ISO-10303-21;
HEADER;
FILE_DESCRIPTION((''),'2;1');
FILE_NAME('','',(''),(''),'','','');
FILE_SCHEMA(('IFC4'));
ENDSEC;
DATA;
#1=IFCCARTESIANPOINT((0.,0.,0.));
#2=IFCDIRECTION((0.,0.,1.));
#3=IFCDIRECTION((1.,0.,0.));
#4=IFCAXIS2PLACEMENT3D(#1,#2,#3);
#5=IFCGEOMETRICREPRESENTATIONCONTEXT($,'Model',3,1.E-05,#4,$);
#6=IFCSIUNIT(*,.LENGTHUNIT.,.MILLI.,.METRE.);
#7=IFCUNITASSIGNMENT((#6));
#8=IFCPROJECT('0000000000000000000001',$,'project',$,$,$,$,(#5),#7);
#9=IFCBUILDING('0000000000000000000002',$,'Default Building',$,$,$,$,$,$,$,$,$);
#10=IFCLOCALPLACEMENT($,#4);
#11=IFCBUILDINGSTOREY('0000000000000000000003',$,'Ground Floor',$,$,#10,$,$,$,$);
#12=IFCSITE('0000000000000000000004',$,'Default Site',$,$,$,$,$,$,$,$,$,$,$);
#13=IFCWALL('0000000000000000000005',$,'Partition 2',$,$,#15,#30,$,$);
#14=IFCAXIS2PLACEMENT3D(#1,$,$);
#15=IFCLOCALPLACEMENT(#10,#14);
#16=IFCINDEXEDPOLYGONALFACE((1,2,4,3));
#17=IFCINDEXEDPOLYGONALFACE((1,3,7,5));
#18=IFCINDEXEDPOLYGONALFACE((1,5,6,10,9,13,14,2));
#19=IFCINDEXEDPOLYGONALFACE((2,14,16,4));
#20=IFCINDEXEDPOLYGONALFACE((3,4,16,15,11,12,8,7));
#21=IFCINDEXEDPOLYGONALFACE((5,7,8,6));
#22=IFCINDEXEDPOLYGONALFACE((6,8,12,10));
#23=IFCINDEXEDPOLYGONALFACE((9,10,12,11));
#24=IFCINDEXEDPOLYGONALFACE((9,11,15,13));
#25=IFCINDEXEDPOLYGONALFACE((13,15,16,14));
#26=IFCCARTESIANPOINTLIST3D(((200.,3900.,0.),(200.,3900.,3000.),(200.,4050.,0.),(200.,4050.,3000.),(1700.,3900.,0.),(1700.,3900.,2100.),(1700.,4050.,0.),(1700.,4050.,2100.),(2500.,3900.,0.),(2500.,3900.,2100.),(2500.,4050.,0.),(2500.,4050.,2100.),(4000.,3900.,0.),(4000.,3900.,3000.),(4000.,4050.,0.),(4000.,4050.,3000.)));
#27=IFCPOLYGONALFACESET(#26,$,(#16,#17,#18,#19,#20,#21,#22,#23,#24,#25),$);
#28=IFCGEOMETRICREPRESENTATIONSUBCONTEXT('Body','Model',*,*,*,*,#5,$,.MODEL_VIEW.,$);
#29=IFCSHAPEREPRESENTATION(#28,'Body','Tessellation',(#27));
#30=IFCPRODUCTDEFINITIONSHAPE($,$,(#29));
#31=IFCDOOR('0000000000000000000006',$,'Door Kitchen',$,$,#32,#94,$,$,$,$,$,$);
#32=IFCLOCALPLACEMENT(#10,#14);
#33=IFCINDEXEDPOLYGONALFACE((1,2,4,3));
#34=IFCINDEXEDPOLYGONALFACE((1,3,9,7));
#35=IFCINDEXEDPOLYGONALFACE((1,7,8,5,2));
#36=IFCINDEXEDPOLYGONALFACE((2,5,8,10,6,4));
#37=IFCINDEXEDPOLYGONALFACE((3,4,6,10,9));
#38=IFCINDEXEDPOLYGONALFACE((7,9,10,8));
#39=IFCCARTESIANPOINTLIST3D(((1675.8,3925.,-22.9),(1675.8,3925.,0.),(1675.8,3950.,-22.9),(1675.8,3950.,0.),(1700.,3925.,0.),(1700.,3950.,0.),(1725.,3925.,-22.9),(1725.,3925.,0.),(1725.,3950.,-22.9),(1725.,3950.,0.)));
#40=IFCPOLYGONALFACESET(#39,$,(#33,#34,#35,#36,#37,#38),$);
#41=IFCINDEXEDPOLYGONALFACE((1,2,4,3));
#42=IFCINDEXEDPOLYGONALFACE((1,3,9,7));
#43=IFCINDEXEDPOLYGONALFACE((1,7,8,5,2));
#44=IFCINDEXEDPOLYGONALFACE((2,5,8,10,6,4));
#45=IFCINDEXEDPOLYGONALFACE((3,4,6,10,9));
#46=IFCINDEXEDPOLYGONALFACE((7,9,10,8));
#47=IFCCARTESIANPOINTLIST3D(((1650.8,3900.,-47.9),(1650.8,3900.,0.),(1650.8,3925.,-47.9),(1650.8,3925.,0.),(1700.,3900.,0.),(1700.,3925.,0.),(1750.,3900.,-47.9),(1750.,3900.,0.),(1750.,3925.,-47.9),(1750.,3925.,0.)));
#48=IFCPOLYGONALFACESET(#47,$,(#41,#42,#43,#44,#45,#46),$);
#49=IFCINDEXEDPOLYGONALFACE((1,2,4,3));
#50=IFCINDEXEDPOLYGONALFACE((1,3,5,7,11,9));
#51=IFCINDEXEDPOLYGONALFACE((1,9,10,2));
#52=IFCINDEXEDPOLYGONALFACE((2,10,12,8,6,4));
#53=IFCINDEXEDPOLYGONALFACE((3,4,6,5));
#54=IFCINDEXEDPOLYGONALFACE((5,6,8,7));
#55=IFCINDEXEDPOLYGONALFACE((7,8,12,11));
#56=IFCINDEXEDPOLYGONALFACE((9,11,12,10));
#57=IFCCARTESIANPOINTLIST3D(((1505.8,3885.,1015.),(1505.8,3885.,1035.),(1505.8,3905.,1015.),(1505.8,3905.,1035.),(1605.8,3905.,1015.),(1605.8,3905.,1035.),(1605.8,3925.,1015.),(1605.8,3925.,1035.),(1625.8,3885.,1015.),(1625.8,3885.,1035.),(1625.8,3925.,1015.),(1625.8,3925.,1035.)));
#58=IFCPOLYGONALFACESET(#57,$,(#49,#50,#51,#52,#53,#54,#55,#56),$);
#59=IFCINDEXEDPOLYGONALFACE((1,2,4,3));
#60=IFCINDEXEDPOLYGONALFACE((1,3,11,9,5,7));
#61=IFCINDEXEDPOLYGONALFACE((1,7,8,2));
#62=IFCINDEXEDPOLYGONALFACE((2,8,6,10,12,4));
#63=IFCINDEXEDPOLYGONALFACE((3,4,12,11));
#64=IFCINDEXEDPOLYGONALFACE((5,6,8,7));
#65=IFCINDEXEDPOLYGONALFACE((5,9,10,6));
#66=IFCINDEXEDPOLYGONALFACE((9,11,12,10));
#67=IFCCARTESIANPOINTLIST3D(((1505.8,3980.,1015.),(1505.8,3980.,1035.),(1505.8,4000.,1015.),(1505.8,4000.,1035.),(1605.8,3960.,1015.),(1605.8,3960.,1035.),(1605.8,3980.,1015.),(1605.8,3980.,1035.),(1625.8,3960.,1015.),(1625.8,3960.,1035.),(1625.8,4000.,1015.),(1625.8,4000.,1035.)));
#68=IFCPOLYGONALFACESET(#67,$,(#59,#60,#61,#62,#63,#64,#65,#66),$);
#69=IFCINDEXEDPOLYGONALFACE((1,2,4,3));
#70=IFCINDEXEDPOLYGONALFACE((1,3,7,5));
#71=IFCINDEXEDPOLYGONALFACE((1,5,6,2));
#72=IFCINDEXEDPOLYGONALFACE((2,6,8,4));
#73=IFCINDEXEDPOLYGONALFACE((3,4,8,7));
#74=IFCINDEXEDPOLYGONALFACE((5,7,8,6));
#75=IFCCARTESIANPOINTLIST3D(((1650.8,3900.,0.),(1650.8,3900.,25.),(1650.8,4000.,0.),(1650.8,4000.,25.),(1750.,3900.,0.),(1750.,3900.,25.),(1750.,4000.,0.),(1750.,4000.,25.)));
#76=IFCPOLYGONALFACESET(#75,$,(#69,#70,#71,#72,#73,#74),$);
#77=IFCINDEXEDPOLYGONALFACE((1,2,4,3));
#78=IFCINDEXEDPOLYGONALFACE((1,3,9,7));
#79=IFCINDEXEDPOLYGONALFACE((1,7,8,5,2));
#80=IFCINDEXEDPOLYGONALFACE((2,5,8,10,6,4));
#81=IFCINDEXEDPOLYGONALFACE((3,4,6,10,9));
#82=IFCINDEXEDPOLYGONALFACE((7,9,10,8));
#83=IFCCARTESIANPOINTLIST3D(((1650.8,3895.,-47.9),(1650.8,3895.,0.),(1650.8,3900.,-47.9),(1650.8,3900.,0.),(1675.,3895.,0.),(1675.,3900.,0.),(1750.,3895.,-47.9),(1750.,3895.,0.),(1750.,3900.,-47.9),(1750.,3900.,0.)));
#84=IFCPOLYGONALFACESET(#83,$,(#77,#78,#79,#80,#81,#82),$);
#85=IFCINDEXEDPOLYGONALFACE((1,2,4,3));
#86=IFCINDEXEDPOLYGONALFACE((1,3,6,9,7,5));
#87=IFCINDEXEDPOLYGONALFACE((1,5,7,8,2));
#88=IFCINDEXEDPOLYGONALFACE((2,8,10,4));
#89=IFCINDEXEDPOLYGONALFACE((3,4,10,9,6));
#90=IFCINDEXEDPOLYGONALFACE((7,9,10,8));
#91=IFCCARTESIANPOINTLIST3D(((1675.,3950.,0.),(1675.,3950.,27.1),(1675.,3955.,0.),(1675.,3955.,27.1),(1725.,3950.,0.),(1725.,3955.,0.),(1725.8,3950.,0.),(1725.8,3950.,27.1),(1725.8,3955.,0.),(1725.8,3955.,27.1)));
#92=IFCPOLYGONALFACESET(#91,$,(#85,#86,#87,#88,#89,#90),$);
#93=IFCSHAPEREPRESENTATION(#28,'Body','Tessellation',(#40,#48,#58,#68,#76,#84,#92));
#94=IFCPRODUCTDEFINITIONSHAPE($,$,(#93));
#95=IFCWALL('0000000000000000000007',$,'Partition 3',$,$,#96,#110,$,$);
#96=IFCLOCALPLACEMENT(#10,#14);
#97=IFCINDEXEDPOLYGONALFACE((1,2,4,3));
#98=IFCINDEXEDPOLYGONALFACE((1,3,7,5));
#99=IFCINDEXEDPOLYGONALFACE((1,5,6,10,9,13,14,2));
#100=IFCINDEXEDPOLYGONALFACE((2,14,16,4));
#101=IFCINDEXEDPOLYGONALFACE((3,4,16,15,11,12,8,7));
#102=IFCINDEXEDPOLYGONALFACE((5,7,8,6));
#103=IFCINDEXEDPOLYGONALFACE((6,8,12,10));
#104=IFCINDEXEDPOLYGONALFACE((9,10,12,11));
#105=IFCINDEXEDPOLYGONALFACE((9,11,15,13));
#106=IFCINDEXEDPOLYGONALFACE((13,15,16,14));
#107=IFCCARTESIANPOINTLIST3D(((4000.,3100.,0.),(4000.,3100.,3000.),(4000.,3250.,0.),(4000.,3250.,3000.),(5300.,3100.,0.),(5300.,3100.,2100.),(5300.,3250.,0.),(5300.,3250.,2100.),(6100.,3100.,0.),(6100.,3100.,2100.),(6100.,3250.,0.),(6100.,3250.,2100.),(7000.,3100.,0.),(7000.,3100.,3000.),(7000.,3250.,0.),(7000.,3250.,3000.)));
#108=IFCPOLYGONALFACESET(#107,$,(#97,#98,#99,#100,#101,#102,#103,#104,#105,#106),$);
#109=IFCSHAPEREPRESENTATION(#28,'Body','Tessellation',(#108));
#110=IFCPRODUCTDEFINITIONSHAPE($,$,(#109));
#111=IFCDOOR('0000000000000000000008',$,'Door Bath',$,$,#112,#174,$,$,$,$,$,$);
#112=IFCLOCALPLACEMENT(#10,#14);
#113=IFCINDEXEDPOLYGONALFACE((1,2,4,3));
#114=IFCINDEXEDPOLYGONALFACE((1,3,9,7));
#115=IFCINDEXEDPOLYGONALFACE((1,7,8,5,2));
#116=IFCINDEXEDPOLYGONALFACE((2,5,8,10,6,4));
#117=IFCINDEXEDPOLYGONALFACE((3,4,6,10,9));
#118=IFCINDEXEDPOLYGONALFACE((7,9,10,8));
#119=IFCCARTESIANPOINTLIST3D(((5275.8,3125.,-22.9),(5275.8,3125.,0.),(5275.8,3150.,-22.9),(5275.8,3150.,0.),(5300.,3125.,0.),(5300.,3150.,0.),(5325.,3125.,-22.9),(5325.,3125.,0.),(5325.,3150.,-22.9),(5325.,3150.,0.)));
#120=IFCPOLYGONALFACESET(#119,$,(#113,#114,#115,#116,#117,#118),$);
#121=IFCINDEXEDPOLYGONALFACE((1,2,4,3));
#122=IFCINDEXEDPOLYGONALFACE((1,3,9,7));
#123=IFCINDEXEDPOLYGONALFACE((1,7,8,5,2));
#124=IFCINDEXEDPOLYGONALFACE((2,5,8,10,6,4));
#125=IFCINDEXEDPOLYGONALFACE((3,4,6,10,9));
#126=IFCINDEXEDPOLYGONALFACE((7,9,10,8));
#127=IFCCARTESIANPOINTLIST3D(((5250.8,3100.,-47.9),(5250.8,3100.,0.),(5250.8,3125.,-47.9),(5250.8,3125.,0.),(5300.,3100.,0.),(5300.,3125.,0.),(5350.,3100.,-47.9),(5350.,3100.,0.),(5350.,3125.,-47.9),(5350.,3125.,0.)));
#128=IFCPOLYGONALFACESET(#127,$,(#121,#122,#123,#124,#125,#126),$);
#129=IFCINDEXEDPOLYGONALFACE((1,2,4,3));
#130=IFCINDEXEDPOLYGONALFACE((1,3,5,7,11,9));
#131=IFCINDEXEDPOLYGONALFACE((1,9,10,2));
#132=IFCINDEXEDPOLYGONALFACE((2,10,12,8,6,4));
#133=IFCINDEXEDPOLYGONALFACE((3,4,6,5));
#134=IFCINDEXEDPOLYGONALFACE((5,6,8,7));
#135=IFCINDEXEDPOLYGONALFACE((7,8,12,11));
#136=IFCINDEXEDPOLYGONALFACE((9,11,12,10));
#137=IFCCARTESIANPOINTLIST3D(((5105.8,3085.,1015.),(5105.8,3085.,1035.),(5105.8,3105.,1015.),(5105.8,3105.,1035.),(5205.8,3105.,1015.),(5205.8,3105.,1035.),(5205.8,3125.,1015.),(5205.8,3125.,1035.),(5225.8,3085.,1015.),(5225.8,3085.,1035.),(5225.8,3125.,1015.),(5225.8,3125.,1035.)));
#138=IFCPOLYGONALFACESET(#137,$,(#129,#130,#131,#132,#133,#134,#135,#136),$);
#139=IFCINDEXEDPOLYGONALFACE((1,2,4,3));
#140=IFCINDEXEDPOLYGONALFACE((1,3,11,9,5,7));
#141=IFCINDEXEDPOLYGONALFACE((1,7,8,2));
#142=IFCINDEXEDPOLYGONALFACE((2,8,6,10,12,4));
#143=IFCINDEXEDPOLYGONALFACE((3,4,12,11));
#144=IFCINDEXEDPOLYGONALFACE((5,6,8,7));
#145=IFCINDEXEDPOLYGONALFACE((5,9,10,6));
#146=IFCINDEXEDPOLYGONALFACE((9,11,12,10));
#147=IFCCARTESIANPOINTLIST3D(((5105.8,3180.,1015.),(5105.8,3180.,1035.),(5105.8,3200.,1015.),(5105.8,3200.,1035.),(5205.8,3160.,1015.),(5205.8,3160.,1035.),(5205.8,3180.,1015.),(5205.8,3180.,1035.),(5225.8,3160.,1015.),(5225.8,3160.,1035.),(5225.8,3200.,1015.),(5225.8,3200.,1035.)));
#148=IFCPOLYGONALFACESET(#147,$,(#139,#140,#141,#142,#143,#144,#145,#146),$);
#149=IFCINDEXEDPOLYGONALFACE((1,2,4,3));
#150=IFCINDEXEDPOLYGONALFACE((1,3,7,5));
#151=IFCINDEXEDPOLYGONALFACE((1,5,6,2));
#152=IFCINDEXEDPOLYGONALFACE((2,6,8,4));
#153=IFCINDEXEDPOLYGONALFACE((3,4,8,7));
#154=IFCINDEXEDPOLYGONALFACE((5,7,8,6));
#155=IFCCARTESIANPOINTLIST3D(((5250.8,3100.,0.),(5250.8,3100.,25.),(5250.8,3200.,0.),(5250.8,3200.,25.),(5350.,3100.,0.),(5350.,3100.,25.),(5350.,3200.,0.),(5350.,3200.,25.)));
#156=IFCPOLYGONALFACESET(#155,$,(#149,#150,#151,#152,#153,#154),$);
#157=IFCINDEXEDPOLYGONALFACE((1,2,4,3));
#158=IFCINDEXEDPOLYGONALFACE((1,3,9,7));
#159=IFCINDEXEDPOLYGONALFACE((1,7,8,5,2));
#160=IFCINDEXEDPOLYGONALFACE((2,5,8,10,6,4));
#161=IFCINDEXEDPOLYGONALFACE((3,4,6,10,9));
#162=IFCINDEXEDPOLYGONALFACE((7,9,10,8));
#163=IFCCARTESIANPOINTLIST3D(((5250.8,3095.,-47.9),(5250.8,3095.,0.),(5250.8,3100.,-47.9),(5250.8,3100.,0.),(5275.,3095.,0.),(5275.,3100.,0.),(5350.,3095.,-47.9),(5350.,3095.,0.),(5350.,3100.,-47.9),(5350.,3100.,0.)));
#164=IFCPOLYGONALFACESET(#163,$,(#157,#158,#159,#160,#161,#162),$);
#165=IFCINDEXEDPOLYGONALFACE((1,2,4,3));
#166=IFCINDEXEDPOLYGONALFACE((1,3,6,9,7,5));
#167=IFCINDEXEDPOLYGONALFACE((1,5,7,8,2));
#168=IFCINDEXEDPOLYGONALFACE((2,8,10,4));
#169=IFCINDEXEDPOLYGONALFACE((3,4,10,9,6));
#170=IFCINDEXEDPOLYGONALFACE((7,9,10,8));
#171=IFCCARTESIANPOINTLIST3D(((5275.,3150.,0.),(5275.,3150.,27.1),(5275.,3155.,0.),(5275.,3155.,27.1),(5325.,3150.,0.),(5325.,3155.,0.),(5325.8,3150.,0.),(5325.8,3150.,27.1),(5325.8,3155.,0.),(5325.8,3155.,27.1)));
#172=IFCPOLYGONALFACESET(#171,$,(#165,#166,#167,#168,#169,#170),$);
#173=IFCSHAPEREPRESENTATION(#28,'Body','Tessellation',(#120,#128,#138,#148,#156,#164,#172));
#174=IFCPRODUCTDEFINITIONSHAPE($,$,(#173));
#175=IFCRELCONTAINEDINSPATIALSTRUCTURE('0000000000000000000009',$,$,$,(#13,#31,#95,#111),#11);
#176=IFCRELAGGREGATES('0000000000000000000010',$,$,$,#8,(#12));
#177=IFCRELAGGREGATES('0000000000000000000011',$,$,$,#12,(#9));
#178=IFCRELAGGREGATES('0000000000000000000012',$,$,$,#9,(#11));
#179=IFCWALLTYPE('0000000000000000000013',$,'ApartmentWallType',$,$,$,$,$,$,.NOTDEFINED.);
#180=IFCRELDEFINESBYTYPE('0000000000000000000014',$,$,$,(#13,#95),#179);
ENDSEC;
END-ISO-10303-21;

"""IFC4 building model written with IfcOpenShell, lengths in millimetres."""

from ifc_helpers import new_model, si_unit, frame, origin_with_axes, place, context, subcontext, project, spatial, line, indexed_curve, outline, extrude, type_object, element, fill, save


model = new_model("IFC4")

# Units and contexts
model_context = context("Model", 3, precision=1e-05, world=origin_with_axes())
body_context = subcontext(model_context, "Body", "Model", "MODEL_VIEW")
ifc_project = project(units=[si_unit("LENGTHUNIT", "METRE", prefix="MILLI")], contexts=[model_context])

# Site, building, storey
site = spatial("IfcSite", under=ifc_project, Name="Default Site")
building = spatial("IfcBuilding", under=site, Name="Default Building")
storey_placement = place(None, origin_with_axes())
storey = spatial("IfcBuildingStorey", under=building, at=storey_placement, Name="Ground Floor")

# Shared definitions
wall_type = type_object("IfcWallType", Name="ApartmentWallType", PredefinedType="NOTDEFINED")

# Walls, openings, doors
wall_1_placement = place(storey_placement, origin_with_axes())
wall_1 = element("IfcWall", 1, at=wall_1_placement, inside=storey, type_object=wall_type, Name="Partition 2", context=body_context, shape_type="SweptSolid", body=[
    extrude(outline(indexed_curve([(200.0, 3900.0), (4000.0, 3900.0), (4000.0, 4050.0), (200.0, 4050.0), (200.0, 3900.0)])), None, (0.0, 0.0, 1.0), 3000.0),
])
opening_1_placement = place(wall_1_placement, origin_with_axes())
opening_1 = element("IfcOpeningElement", 2, at=opening_1_placement, cuts=wall_1, context=body_context, shape_type="SweptSolid", body=[
    extrude(outline(indexed_curve([(1700.0, 3900.0), (2500.0, 3900.0), (2500.0, 4050.0), (1700.0, 4050.0), (1700.0, 3900.0)])), None, (0.0, 0.0, 1.0), 2100.0),
])
door_1_placement = place(storey_placement, frame((1700.0, 3900.0, 0.0), z_axis=(0.0, 0.0, 1.0), x_axis=(1.0, 0.0, 0.0)))
door_1 = element("IfcDoor", 3, at=door_1_placement, inside=storey, Name="Door Kitchen", context=body_context, shape_type="SweptSolid", body=[
    extrude(outline(indexed_curve([(0.0, 0.0), (0.0, 2.1), (0.8, 2.1), (0.8, 0.0), (-24.2, 0.0), (-24.2, -22.9), (25.0, -22.9), (25.0, 0.0)], segments=[line(1, 2, 3, 4, 5, 6, 7, 8, 1)])), frame((0.0, 25.0, 0.0), z_axis=(0.0, -1.0, 0.0), x_axis=(1.0, 0.0, 0.0)), (0.0, 0.0, -1.0), 25.0),
    extrude(outline(indexed_curve([(0.0, 0.0), (0.0, 2.1), (0.8, 2.1), (0.8, 0.0), (-49.2, 0.0), (-49.2, -47.9), (50.0, -47.9), (50.0, 0.0)], segments=[line(1, 2, 3, 4, 5, 6, 7, 8, 1)])), frame((0.0, 0.0, 0.0), z_axis=(0.0, -1.0, 0.0), x_axis=(1.0, 0.0, 0.0)), (0.0, 0.0, -1.0), 25.0),
    extrude(outline(indexed_curve([(0.0, 0.0), (-49.2, 0.0), (-49.2, 35.0), (0.0, 35.0)], segments=[line(1, 2, 3, 4, 1)])), frame((25.0, 25.0, 25.0), z_axis=(0.0, 0.0, 1.0), x_axis=(1.0, 0.0, 0.0)), (0.0, 0.0, 1.0), -47.9),
    extrude(outline(indexed_curve([(0.0, 0.0), (0.0, -40.0), (-120.0, -40.0), (-120.0, -20.0), (-20.0, -20.0), (-20.0, 0.0)], segments=[line(1, 2, 3, 4, 5, 6, 1)])), frame((-74.2, 25.0, 1015.0), z_axis=(0.0, 0.0, 1.0), x_axis=(1.0, 0.0, 0.0)), (0.0, 0.0, 1.0), 20.0),
    extrude(outline(indexed_curve([(0.0, 0.0), (0.0, 40.0), (-120.0, 40.0), (-120.0, 20.0), (-20.0, 20.0), (-20.0, 0.0)], segments=[line(1, 2, 3, 4, 5, 6, 1)])), frame((-74.2, 60.0, 1015.0), z_axis=(0.0, 0.0, 1.0), x_axis=(1.0, 0.0, 0.0)), (0.0, 0.0, 1.0), 20.0),
    extrude(outline(indexed_curve([(0.0, 0.0), (-99.2, 0.0), (-99.2, 100.0), (0.0, 100.0)], segments=[line(1, 2, 3, 4, 1)])), frame((50.0, 0.0, 0.0), z_axis=(0.0, 0.0, 1.0), x_axis=(1.0, 0.0, 0.0)), (0.0, 0.0, 1.0), 25.0),
    extrude(outline(indexed_curve([(0.0, 0.0), (0.0, 27.1), (50.8, 27.1), (50.8, 0.0), (-24.2, 0.0), (-24.2, -47.9), (75.0, -47.9), (75.0, 0.0)], segments=[line(1, 2, 3, 4, 5, 6, 7, 8, 1)])), frame((-25.0, -5.0, 0.0), z_axis=(0.0, -1.0, 0.0), x_axis=(1.0, 0.0, 0.0)), (0.0, 0.0, -1.0), 5.0),
    extrude(outline(indexed_curve([(0.0, 0.0), (0.0, 27.1), (50.8, 27.1), (50.8, 0.0), (0.8, 0.0), (0.8, -22.9), (50.0, -22.9), (50.0, 0.0)], segments=[line(1, 2, 3, 4, 5, 6, 7, 8, 1)])), frame((-25.0, 50.0, 0.0), z_axis=(0.0, -1.0, 0.0), x_axis=(1.0, 0.0, 0.0)), (0.0, 0.0, -1.0), 5.0),
])
fill(opening_1, door_1)
wall_2_placement = place(storey_placement, origin_with_axes())
wall_2 = element("IfcWall", 4, at=wall_2_placement, inside=storey, type_object=wall_type, Name="Partition 3", context=body_context, shape_type="SweptSolid", body=[
    extrude(outline(indexed_curve([(4000.0, 3100.0), (7000.0, 3100.0), (7000.0, 3250.0), (4000.0, 3250.0), (4000.0, 3100.0)])), None, (0.0, 0.0, 1.0), 3000.0),
])
opening_2_placement = place(wall_2_placement, origin_with_axes())
opening_2 = element("IfcOpeningElement", 5, at=opening_2_placement, cuts=wall_2, context=body_context, shape_type="SweptSolid", body=[
    extrude(outline(indexed_curve([(5300.0, 3100.0), (6100.0, 3100.0), (6100.0, 3250.0), (5300.0, 3250.0), (5300.0, 3100.0)])), None, (0.0, 0.0, 1.0), 2100.0),
])
door_2_placement = place(storey_placement, frame((5300.0, 3100.0, 0.0), z_axis=(0.0, 0.0, 1.0), x_axis=(1.0, 0.0, 0.0)))
door_2 = element("IfcDoor", 6, at=door_2_placement, inside=storey, Name="Door Bath", context=body_context, shape_type="SweptSolid", body=[
    extrude(outline(indexed_curve([(0.0, 0.0), (0.0, 2.1), (0.8, 2.1), (0.8, 0.0), (-24.2, 0.0), (-24.2, -22.9), (25.0, -22.9), (25.0, 0.0)], segments=[line(1, 2, 3, 4, 5, 6, 7, 8, 1)])), frame((0.0, 25.0, 0.0), z_axis=(0.0, -1.0, 0.0), x_axis=(1.0, 0.0, 0.0)), (0.0, 0.0, -1.0), 25.0),
    extrude(outline(indexed_curve([(0.0, 0.0), (0.0, 2.1), (0.8, 2.1), (0.8, 0.0), (-49.2, 0.0), (-49.2, -47.9), (50.0, -47.9), (50.0, 0.0)], segments=[line(1, 2, 3, 4, 5, 6, 7, 8, 1)])), frame((0.0, 0.0, 0.0), z_axis=(0.0, -1.0, 0.0), x_axis=(1.0, 0.0, 0.0)), (0.0, 0.0, -1.0), 25.0),
    extrude(outline(indexed_curve([(0.0, 0.0), (-49.2, 0.0), (-49.2, 35.0), (0.0, 35.0)], segments=[line(1, 2, 3, 4, 1)])), frame((25.0, 25.0, 25.0), z_axis=(0.0, 0.0, 1.0), x_axis=(1.0, 0.0, 0.0)), (0.0, 0.0, 1.0), -47.9),
    extrude(outline(indexed_curve([(0.0, 0.0), (0.0, -40.0), (-120.0, -40.0), (-120.0, -20.0), (-20.0, -20.0), (-20.0, 0.0)], segments=[line(1, 2, 3, 4, 5, 6, 1)])), frame((-74.2, 25.0, 1015.0), z_axis=(0.0, 0.0, 1.0), x_axis=(1.0, 0.0, 0.0)), (0.0, 0.0, 1.0), 20.0),
    extrude(outline(indexed_curve([(0.0, 0.0), (0.0, 40.0), (-120.0, 40.0), (-120.0, 20.0), (-20.0, 20.0), (-20.0, 0.0)], segments=[line(1, 2, 3, 4, 5, 6, 1)])), frame((-74.2, 60.0, 1015.0), z_axis=(0.0, 0.0, 1.0), x_axis=(1.0, 0.0, 0.0)), (0.0, 0.0, 1.0), 20.0),
    extrude(outline(indexed_curve([(0.0, 0.0), (-99.2, 0.0), (-99.2, 100.0), (0.0, 100.0)], segments=[line(1, 2, 3, 4, 1)])), frame((50.0, 0.0, 0.0), z_axis=(0.0, 0.0, 1.0), x_axis=(1.0, 0.0, 0.0)), (0.0, 0.0, 1.0), 25.0),
    extrude(outline(indexed_curve([(0.0, 0.0), (0.0, 27.1), (50.8, 27.1), (50.8, 0.0), (-24.2, 0.0), (-24.2, -47.9), (75.0, -47.9), (75.0, 0.0)], segments=[line(1, 2, 3, 4, 5, 6, 7, 8, 1)])), frame((-25.0, -5.0, 0.0), z_axis=(0.0, -1.0, 0.0), x_axis=(1.0, 0.0, 0.0)), (0.0, 0.0, -1.0), 5.0),
    extrude(outline(indexed_curve([(0.0, 0.0), (0.0, 27.1), (50.8, 27.1), (50.8, 0.0), (0.8, 0.0), (0.8, -22.9), (50.0, -22.9), (50.0, 0.0)], segments=[line(1, 2, 3, 4, 5, 6, 7, 8, 1)])), frame((-25.0, 50.0, 0.0), z_axis=(0.0, -1.0, 0.0), x_axis=(1.0, 0.0, 0.0)), (0.0, 0.0, -1.0), 5.0),
])
fill(opening_2, door_2)

save(model, "model.ifc")
